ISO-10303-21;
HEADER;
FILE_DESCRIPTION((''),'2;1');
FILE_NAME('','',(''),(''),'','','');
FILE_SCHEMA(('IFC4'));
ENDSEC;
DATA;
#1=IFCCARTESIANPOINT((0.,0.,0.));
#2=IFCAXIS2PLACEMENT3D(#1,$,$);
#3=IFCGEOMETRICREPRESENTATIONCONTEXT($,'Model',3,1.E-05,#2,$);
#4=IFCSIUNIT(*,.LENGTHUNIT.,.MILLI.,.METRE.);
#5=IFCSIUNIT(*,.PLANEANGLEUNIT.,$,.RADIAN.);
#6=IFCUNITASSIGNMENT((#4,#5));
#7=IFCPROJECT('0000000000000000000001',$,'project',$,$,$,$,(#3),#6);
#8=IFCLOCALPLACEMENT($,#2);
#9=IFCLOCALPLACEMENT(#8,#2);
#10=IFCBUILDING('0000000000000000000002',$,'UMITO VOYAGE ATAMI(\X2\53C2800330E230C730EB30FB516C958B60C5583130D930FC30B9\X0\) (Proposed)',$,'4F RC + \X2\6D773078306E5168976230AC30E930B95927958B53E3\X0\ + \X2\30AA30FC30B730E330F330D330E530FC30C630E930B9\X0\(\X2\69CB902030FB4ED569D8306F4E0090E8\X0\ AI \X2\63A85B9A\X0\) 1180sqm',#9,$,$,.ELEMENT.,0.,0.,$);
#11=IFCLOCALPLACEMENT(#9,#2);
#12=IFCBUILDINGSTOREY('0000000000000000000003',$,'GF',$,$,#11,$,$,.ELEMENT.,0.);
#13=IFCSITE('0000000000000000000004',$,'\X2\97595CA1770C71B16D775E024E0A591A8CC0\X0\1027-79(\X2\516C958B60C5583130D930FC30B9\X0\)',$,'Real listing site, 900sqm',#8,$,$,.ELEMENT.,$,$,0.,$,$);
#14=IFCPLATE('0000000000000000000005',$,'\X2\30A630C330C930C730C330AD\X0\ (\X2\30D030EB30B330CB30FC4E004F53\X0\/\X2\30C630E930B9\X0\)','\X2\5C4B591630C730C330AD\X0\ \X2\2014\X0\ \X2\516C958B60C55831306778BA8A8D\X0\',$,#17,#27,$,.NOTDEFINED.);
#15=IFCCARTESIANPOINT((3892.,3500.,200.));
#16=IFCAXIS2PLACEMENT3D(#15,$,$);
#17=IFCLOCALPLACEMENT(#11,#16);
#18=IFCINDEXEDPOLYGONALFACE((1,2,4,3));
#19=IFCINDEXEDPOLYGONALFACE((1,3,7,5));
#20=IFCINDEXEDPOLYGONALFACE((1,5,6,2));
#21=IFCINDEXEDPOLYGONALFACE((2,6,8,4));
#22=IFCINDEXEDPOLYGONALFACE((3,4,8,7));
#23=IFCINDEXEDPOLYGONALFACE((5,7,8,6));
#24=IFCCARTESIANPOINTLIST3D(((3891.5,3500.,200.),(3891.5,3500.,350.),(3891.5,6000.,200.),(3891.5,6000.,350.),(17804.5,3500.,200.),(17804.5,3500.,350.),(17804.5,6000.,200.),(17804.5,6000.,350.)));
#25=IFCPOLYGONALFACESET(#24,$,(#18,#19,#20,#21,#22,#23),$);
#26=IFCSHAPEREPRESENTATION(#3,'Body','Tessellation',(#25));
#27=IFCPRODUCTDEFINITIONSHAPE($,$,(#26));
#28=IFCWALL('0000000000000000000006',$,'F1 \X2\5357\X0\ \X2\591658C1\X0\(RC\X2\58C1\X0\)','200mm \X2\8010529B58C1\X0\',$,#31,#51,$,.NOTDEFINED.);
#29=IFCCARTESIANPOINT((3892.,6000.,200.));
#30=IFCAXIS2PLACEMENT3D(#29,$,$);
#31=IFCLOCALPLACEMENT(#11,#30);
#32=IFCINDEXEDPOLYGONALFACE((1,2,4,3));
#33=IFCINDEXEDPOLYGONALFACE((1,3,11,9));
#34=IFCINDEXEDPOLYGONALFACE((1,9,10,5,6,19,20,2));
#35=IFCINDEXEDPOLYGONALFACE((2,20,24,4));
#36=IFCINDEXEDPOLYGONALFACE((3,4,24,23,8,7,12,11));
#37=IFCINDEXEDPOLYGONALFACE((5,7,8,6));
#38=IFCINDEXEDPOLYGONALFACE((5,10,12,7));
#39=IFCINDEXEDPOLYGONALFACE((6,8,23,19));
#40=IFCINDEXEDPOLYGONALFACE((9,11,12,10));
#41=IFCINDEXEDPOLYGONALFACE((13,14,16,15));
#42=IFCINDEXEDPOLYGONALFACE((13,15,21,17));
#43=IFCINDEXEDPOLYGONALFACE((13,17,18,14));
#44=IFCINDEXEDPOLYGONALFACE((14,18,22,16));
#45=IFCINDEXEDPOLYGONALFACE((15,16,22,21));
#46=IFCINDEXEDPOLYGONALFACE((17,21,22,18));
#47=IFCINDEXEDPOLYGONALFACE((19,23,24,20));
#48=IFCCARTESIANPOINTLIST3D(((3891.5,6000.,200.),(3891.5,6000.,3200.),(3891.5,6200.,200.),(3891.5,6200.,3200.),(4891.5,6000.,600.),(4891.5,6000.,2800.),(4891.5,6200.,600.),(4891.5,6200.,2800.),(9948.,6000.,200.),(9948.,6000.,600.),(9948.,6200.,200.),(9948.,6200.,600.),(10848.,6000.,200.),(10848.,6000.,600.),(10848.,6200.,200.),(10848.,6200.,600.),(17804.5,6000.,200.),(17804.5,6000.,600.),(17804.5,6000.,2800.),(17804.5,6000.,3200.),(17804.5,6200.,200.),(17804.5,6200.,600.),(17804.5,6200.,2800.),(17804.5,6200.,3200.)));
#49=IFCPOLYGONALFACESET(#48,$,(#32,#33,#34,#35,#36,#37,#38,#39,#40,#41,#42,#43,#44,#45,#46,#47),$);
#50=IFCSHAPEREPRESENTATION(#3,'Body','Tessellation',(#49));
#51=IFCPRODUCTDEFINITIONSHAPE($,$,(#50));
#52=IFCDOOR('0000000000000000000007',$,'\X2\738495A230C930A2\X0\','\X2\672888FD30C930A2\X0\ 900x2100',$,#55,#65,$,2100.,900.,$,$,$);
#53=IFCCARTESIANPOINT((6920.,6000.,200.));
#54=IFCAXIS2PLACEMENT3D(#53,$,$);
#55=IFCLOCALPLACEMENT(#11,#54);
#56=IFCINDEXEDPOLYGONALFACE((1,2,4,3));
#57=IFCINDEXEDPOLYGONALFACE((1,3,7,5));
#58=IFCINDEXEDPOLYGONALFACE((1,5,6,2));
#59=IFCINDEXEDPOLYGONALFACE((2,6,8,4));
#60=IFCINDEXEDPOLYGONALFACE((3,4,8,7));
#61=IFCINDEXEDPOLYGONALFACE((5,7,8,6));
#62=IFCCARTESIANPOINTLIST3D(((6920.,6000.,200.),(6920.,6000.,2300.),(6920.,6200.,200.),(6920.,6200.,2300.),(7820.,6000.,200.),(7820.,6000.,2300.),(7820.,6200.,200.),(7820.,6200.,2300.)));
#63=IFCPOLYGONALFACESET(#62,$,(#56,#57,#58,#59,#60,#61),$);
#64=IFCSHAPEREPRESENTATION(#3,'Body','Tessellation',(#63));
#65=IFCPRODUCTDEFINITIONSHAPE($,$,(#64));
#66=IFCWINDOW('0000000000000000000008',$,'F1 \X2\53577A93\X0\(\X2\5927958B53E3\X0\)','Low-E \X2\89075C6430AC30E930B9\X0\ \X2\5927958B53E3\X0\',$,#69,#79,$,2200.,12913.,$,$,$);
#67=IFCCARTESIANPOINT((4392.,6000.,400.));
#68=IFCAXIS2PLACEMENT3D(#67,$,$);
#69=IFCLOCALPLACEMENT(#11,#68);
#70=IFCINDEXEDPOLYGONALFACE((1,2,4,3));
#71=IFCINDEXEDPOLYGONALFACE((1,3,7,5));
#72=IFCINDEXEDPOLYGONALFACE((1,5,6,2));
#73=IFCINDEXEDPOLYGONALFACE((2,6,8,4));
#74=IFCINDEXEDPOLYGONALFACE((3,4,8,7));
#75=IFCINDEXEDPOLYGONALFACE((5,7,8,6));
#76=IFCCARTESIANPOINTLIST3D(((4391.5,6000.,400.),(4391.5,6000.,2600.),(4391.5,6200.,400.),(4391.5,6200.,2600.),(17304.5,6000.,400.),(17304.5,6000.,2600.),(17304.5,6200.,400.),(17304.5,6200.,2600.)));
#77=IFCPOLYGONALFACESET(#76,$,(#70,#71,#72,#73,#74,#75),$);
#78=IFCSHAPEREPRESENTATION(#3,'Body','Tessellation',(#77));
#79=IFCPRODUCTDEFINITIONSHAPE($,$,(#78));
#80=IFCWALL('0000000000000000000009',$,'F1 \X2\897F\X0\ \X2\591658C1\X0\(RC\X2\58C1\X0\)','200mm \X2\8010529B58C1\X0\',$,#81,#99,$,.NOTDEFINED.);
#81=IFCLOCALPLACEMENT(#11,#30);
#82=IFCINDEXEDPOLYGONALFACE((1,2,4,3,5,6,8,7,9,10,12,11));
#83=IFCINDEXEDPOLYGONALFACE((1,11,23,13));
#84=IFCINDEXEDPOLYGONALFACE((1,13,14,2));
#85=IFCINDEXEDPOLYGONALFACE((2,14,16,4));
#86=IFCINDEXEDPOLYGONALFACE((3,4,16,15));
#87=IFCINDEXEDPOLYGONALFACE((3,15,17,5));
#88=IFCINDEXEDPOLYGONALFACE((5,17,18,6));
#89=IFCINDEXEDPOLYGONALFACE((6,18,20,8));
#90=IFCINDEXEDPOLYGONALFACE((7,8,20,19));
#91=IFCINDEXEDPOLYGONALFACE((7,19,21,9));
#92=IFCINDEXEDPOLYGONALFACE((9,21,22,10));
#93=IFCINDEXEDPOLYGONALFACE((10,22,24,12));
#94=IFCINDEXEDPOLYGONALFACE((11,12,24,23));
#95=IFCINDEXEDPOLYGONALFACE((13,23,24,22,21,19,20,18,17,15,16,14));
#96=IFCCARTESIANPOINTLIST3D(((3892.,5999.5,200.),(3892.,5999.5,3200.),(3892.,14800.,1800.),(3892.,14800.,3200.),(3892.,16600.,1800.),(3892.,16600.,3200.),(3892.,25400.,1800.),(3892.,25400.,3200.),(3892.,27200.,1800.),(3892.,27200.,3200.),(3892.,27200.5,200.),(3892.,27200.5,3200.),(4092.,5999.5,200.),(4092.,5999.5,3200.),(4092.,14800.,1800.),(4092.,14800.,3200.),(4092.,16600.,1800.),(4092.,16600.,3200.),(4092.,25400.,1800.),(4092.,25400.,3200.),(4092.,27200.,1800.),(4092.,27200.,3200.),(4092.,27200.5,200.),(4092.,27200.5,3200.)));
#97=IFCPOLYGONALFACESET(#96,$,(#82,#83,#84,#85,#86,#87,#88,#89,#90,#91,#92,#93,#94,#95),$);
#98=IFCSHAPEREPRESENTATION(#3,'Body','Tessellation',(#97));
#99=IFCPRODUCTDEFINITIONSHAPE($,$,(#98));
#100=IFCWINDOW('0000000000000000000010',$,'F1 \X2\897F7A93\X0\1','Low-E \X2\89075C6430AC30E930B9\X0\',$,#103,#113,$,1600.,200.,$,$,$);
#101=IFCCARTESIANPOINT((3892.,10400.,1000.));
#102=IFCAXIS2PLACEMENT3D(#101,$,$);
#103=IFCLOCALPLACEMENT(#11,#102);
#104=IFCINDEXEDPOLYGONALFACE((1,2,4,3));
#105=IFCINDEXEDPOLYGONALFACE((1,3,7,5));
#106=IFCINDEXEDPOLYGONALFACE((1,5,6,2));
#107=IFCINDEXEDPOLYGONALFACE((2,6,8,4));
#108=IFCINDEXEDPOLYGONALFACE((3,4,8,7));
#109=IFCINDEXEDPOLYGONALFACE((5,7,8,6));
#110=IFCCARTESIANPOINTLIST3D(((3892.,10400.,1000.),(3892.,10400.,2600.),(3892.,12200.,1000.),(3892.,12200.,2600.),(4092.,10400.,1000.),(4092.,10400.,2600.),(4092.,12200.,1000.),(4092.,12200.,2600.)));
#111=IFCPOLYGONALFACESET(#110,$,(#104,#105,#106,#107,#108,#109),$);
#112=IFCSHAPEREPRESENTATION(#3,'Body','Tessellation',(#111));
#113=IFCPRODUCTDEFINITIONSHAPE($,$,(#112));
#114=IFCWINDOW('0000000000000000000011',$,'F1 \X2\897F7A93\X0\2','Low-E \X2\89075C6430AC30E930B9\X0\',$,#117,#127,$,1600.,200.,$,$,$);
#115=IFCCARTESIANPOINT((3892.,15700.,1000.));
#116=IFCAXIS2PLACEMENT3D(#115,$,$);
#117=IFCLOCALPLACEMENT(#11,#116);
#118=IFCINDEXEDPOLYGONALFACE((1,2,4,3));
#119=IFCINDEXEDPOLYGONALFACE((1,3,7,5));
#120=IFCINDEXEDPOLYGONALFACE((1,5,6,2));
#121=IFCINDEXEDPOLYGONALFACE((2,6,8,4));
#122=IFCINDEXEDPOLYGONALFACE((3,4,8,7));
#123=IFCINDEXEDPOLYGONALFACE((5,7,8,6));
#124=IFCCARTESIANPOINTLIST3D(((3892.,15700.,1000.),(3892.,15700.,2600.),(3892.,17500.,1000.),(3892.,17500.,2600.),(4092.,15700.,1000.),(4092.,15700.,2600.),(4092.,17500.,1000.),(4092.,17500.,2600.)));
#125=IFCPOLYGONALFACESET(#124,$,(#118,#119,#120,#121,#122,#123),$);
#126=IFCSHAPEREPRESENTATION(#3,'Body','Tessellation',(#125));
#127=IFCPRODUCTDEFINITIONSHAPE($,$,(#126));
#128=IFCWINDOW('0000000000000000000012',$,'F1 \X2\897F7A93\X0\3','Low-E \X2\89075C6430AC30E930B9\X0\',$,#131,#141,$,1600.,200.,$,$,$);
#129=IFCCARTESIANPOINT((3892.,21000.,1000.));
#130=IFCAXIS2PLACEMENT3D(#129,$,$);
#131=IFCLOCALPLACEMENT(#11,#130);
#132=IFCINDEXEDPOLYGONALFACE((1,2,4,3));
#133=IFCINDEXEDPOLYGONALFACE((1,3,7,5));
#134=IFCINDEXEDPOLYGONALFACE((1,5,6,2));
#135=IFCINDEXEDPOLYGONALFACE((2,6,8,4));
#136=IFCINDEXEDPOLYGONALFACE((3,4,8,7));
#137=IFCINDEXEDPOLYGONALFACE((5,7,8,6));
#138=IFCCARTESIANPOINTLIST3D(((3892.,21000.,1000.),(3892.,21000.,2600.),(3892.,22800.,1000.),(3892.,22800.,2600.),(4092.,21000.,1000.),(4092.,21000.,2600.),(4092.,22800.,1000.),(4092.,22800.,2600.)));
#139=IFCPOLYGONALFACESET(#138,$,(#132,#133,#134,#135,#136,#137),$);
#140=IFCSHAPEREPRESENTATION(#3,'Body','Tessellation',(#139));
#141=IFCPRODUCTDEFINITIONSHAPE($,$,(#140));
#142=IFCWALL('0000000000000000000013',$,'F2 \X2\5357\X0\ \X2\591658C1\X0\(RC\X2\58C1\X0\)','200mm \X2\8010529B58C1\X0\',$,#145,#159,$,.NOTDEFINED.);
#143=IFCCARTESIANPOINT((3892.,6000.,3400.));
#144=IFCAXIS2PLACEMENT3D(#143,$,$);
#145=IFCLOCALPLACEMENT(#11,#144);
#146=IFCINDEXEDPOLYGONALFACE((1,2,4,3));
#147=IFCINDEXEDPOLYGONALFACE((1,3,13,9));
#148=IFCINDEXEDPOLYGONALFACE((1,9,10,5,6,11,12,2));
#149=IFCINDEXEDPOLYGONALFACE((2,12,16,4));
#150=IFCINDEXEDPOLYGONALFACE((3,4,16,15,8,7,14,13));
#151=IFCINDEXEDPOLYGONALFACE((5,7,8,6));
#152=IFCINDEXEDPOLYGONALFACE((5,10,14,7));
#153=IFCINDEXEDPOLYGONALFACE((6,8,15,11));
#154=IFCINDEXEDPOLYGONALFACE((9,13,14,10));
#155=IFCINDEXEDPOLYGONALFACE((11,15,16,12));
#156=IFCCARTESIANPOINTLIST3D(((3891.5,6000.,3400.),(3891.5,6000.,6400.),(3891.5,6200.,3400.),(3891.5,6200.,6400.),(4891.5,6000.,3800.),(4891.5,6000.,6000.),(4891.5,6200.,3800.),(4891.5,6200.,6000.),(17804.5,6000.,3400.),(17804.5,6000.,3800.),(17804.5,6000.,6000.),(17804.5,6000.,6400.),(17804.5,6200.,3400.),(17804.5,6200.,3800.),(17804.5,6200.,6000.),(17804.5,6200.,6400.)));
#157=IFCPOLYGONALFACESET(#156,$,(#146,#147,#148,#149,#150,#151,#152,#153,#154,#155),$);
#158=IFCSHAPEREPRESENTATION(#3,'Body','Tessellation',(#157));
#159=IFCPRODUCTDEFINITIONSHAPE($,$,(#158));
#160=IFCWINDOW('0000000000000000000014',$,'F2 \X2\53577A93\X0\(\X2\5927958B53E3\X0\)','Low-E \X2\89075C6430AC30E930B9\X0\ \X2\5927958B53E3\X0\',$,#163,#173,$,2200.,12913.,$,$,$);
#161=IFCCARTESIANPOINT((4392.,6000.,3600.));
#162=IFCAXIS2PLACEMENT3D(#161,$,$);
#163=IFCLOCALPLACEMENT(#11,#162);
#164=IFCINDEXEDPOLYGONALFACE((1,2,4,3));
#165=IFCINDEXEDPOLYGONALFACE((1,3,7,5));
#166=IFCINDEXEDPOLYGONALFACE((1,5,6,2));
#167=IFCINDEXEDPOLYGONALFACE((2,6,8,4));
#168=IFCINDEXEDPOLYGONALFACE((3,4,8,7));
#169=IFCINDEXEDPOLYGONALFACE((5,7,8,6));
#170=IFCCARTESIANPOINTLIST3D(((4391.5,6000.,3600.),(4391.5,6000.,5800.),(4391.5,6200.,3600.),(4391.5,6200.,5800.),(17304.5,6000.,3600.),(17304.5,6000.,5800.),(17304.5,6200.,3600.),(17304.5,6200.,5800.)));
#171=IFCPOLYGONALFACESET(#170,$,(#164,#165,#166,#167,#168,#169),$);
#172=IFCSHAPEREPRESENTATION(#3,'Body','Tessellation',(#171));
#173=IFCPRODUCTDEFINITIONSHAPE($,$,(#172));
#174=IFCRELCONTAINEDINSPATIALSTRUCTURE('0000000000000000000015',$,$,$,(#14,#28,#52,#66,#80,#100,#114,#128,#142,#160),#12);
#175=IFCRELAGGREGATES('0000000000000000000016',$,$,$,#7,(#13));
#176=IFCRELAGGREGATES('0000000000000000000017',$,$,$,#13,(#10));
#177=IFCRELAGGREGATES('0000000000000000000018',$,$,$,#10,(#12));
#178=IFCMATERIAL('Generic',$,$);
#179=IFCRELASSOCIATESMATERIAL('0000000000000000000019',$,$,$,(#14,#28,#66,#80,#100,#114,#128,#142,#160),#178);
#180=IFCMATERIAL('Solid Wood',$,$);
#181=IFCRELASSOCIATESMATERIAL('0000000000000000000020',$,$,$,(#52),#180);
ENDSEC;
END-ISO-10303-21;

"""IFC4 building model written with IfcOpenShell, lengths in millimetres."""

from ifc_helpers import new_model, si_unit, frame, frame_2d, origin, place, context, project, spatial, rectangle, extrude, material, element, fill, save


model = new_model("IFC4")

# Units and contexts
model_context = context("Model", 3, precision=1e-05, world=origin())
ifc_project = project(units=[si_unit("LENGTHUNIT", "METRE", prefix="MILLI"), si_unit("PLANEANGLEUNIT", "RADIAN")], contexts=[model_context])

# Site, building, storey
site_placement = place(None, origin())
site = spatial("IfcSite", under=ifc_project, at=site_placement, Name="静岡県熱海市上多賀1027-79(公開情報ベース)", ObjectType="Real listing site, 900sqm", CompositionType="ELEMENT", RefElevation=0.0)
building_placement = place(site_placement, origin())
building = spatial("IfcBuilding", under=site, at=building_placement, Name="UMITO VOYAGE ATAMI(参考モデル・公開情報ベース) (Proposed)", ObjectType="4F RC + 海への全面ガラス大開口 + オーシャンビューテラス(構造・仕様は一部 AI 推定) 1180sqm", CompositionType="ELEMENT", ElevationOfRefHeight=0.0, ElevationOfTerrain=0.0)
storey_placement = place(building_placement, origin())
storey = spatial("IfcBuildingStorey", under=building, at=storey_placement, Name="GF", CompositionType="ELEMENT", Elevation=0.0)

# Plate
ifc_material_1 = material(Name="Generic")
plate_placement = place(storey_placement, frame((3892.0, 3500.0, 200.0)))
element("IfcPlate", 1, at=plate_placement, inside=storey, material=ifc_material_1, Name="ウッドデッキ (バルコニー一体/テラス)", Description="屋外デッキ — 公開情報で確認", PredefinedType="NOTDEFINED", context=model_context, shape_type="SweptSolid", body=[
    extrude(rectangle(XDim=13913.0, YDim=2500.0, at=frame_2d((6956.0, 1250.0))), frame((3892.0, 3500.0, 200.0)), (0.0, 0.0, 1.0), 150.0),
])

# Wall, openings, door, window
wall_1_placement = place(storey_placement, frame((3892.0, 6000.0, 200.0)))
wall_1 = element("IfcWall", 2, at=wall_1_placement, inside=storey, material=ifc_material_1, Name="F1 南 外壁(RC壁)", Description="200mm 耐力壁", PredefinedType="NOTDEFINED", context=model_context, shape_type="SweptSolid", body=[
    extrude(rectangle(XDim=13913.0, YDim=200.0, at=frame_2d((6956.0, 100.0))), frame((3892.0, 6000.0, 200.0)), (0.0, 0.0, 1.0), 3000.0),
])
opening_1_placement = place(storey_placement, frame((6920.0, 6000.0, 200.0)))
opening_1 = element("IfcOpeningElement", 3, at=opening_1_placement, cuts=wall_1, PredefinedType="NOTDEFINED", context=model_context, shape_type="SweptSolid", body=[
    extrude(rectangle(XDim=900.0, YDim=200.0, at=frame_2d((450.0, 100.0))), frame((6920.0, 6000.0, 200.0)), (0.0, 0.0, 1.0), 2100.0),
])
opening_2_placement = place(storey_placement, frame((4392.0, 6000.0, 400.0)))
opening_2 = element("IfcOpeningElement", 4, at=opening_2_placement, cuts=wall_1, PredefinedType="NOTDEFINED", context=model_context, shape_type="SweptSolid", body=[
    extrude(rectangle(XDim=12913.0, YDim=200.0, at=frame_2d((6456.0, 100.0))), frame((4392.0, 6000.0, 400.0)), (0.0, 0.0, 1.0), 2200.0),
])
ifc_material_2 = material(Name="Solid Wood")
door_placement = place(storey_placement, frame((6920.0, 6000.0, 200.0)))
door = element("IfcDoor", 5, at=door_placement, inside=storey, material=ifc_material_2, Name="玄関ドア", Description="木製ドア 900x2100", OverallHeight=2100.0, OverallWidth=900.0, context=model_context, shape_type="SweptSolid", body=[
    extrude(rectangle(XDim=900.0, YDim=200.0, at=frame_2d((450.0, 100.0))), frame((6920.0, 6000.0, 200.0)), (0.0, 0.0, 1.0), 2100.0),
])
fill(opening_1, door)
window_1_placement = place(storey_placement, frame((4392.0, 6000.0, 400.0)))
window_1 = element("IfcWindow", 6, at=window_1_placement, inside=storey, material=ifc_material_1, Name="F1 南窓(大開口)", Description="Low-E 複層ガラス 大開口", OverallHeight=2200.0, OverallWidth=12913.0, context=model_context, shape_type="SweptSolid", body=[
    extrude(rectangle(XDim=12913.0, YDim=200.0, at=frame_2d((6456.0, 100.0))), frame((4392.0, 6000.0, 400.0)), (0.0, 0.0, 1.0), 2200.0),
])
fill(opening_2, window_1)

# Wall, openings, windows
wall_2_placement = place(storey_placement, frame((3892.0, 6000.0, 200.0)))
wall_2 = element("IfcWall", 7, at=wall_2_placement, inside=storey, material=ifc_material_1, Name="F1 西 外壁(RC壁)", Description="200mm 耐力壁", PredefinedType="NOTDEFINED", context=model_context, shape_type="SweptSolid", body=[
    extrude(rectangle(XDim=200.0, YDim=21201.0, at=frame_2d((100.0, 10600.0))), frame((3892.0, 6000.0, 200.0)), (0.0, 0.0, 1.0), 3000.0),
])
opening_3_placement = place(storey_placement, frame((3892.0, 10400.0, 1000.0)))
opening_3 = element("IfcOpeningElement", 8, at=opening_3_placement, cuts=wall_2, PredefinedType="NOTDEFINED", context=model_context, shape_type="SweptSolid", body=[
    extrude(rectangle(XDim=200.0, YDim=1800.0, at=frame_2d((100.0, 900.0))), frame((3892.0, 10400.0, 1000.0)), (0.0, 0.0, 1.0), 1600.0),
])
opening_4_placement = place(storey_placement, frame((3892.0, 15700.0, 1000.0)))
opening_4 = element("IfcOpeningElement", 9, at=opening_4_placement, cuts=wall_2, PredefinedType="NOTDEFINED", context=model_context, shape_type="SweptSolid", body=[
    extrude(rectangle(XDim=200.0, YDim=1800.0, at=frame_2d((100.0, 900.0))), frame((3892.0, 15700.0, 1000.0)), (0.0, 0.0, 1.0), 1600.0),
])
opening_5_placement = place(storey_placement, frame((3892.0, 21000.0, 1000.0)))
opening_5 = element("IfcOpeningElement", 10, at=opening_5_placement, cuts=wall_2, PredefinedType="NOTDEFINED", context=model_context, shape_type="SweptSolid", body=[
    extrude(rectangle(XDim=200.0, YDim=1800.0, at=frame_2d((100.0, 900.0))), frame((3892.0, 21000.0, 1000.0)), (0.0, 0.0, 1.0), 1600.0),
])
window_2_placement = place(storey_placement, frame((3892.0, 10400.0, 1000.0)))
window_2 = element("IfcWindow", 11, at=window_2_placement, inside=storey, material=ifc_material_1, Name="F1 西窓1", Description="Low-E 複層ガラス", OverallHeight=1600.0, OverallWidth=200.0, context=model_context, shape_type="SweptSolid", body=[
    extrude(rectangle(XDim=200.0, YDim=1800.0, at=frame_2d((100.0, 900.0))), frame((3892.0, 10400.0, 1000.0)), (0.0, 0.0, 1.0), 1600.0),
])
fill(opening_3, window_2)
window_3_placement = place(storey_placement, frame((3892.0, 15700.0, 1000.0)))
window_3 = element("IfcWindow", 12, at=window_3_placement, inside=storey, material=ifc_material_1, Name="F1 西窓2", Description="Low-E 複層ガラス", OverallHeight=1600.0, OverallWidth=200.0, context=model_context, shape_type="SweptSolid", body=[
    extrude(rectangle(XDim=200.0, YDim=1800.0, at=frame_2d((100.0, 900.0))), frame((3892.0, 15700.0, 1000.0)), (0.0, 0.0, 1.0), 1600.0),
])
fill(opening_4, window_3)
window_4_placement = place(storey_placement, frame((3892.0, 21000.0, 1000.0)))
window_4 = element("IfcWindow", 13, at=window_4_placement, inside=storey, material=ifc_material_1, Name="F1 西窓3", Description="Low-E 複層ガラス", OverallHeight=1600.0, OverallWidth=200.0, context=model_context, shape_type="SweptSolid", body=[
    extrude(rectangle(XDim=200.0, YDim=1800.0, at=frame_2d((100.0, 900.0))), frame((3892.0, 21000.0, 1000.0)), (0.0, 0.0, 1.0), 1600.0),
])
fill(opening_5, window_4)

# Wall, opening, window
wall_3_placement = place(storey_placement, frame((3892.0, 6000.0, 3400.0)))
wall_3 = element("IfcWall", 14, at=wall_3_placement, inside=storey, material=ifc_material_1, Name="F2 南 外壁(RC壁)", Description="200mm 耐力壁", PredefinedType="NOTDEFINED", context=model_context, shape_type="SweptSolid", body=[
    extrude(rectangle(XDim=13913.0, YDim=200.0, at=frame_2d((6956.0, 100.0))), frame((3892.0, 6000.0, 3400.0)), (0.0, 0.0, 1.0), 3000.0),
])
opening_6_placement = place(storey_placement, frame((4392.0, 6000.0, 3600.0)))
opening_6 = element("IfcOpeningElement", 15, at=opening_6_placement, cuts=wall_3, PredefinedType="NOTDEFINED", context=model_context, shape_type="SweptSolid", body=[
    extrude(rectangle(XDim=12913.0, YDim=200.0, at=frame_2d((6456.0, 100.0))), frame((4392.0, 6000.0, 3600.0)), (0.0, 0.0, 1.0), 2200.0),
])
window_5_placement = place(storey_placement, frame((4392.0, 6000.0, 3600.0)))
window_5 = element("IfcWindow", 16, at=window_5_placement, inside=storey, material=ifc_material_1, Name="F2 南窓(大開口)", Description="Low-E 複層ガラス 大開口", OverallHeight=2200.0, OverallWidth=12913.0, context=model_context, shape_type="SweptSolid", body=[
    extrude(rectangle(XDim=12913.0, YDim=200.0, at=frame_2d((6456.0, 100.0))), frame((4392.0, 6000.0, 3600.0)), (0.0, 0.0, 1.0), 2200.0),
])
fill(opening_6, window_5)

save(model, "model.ifc")
